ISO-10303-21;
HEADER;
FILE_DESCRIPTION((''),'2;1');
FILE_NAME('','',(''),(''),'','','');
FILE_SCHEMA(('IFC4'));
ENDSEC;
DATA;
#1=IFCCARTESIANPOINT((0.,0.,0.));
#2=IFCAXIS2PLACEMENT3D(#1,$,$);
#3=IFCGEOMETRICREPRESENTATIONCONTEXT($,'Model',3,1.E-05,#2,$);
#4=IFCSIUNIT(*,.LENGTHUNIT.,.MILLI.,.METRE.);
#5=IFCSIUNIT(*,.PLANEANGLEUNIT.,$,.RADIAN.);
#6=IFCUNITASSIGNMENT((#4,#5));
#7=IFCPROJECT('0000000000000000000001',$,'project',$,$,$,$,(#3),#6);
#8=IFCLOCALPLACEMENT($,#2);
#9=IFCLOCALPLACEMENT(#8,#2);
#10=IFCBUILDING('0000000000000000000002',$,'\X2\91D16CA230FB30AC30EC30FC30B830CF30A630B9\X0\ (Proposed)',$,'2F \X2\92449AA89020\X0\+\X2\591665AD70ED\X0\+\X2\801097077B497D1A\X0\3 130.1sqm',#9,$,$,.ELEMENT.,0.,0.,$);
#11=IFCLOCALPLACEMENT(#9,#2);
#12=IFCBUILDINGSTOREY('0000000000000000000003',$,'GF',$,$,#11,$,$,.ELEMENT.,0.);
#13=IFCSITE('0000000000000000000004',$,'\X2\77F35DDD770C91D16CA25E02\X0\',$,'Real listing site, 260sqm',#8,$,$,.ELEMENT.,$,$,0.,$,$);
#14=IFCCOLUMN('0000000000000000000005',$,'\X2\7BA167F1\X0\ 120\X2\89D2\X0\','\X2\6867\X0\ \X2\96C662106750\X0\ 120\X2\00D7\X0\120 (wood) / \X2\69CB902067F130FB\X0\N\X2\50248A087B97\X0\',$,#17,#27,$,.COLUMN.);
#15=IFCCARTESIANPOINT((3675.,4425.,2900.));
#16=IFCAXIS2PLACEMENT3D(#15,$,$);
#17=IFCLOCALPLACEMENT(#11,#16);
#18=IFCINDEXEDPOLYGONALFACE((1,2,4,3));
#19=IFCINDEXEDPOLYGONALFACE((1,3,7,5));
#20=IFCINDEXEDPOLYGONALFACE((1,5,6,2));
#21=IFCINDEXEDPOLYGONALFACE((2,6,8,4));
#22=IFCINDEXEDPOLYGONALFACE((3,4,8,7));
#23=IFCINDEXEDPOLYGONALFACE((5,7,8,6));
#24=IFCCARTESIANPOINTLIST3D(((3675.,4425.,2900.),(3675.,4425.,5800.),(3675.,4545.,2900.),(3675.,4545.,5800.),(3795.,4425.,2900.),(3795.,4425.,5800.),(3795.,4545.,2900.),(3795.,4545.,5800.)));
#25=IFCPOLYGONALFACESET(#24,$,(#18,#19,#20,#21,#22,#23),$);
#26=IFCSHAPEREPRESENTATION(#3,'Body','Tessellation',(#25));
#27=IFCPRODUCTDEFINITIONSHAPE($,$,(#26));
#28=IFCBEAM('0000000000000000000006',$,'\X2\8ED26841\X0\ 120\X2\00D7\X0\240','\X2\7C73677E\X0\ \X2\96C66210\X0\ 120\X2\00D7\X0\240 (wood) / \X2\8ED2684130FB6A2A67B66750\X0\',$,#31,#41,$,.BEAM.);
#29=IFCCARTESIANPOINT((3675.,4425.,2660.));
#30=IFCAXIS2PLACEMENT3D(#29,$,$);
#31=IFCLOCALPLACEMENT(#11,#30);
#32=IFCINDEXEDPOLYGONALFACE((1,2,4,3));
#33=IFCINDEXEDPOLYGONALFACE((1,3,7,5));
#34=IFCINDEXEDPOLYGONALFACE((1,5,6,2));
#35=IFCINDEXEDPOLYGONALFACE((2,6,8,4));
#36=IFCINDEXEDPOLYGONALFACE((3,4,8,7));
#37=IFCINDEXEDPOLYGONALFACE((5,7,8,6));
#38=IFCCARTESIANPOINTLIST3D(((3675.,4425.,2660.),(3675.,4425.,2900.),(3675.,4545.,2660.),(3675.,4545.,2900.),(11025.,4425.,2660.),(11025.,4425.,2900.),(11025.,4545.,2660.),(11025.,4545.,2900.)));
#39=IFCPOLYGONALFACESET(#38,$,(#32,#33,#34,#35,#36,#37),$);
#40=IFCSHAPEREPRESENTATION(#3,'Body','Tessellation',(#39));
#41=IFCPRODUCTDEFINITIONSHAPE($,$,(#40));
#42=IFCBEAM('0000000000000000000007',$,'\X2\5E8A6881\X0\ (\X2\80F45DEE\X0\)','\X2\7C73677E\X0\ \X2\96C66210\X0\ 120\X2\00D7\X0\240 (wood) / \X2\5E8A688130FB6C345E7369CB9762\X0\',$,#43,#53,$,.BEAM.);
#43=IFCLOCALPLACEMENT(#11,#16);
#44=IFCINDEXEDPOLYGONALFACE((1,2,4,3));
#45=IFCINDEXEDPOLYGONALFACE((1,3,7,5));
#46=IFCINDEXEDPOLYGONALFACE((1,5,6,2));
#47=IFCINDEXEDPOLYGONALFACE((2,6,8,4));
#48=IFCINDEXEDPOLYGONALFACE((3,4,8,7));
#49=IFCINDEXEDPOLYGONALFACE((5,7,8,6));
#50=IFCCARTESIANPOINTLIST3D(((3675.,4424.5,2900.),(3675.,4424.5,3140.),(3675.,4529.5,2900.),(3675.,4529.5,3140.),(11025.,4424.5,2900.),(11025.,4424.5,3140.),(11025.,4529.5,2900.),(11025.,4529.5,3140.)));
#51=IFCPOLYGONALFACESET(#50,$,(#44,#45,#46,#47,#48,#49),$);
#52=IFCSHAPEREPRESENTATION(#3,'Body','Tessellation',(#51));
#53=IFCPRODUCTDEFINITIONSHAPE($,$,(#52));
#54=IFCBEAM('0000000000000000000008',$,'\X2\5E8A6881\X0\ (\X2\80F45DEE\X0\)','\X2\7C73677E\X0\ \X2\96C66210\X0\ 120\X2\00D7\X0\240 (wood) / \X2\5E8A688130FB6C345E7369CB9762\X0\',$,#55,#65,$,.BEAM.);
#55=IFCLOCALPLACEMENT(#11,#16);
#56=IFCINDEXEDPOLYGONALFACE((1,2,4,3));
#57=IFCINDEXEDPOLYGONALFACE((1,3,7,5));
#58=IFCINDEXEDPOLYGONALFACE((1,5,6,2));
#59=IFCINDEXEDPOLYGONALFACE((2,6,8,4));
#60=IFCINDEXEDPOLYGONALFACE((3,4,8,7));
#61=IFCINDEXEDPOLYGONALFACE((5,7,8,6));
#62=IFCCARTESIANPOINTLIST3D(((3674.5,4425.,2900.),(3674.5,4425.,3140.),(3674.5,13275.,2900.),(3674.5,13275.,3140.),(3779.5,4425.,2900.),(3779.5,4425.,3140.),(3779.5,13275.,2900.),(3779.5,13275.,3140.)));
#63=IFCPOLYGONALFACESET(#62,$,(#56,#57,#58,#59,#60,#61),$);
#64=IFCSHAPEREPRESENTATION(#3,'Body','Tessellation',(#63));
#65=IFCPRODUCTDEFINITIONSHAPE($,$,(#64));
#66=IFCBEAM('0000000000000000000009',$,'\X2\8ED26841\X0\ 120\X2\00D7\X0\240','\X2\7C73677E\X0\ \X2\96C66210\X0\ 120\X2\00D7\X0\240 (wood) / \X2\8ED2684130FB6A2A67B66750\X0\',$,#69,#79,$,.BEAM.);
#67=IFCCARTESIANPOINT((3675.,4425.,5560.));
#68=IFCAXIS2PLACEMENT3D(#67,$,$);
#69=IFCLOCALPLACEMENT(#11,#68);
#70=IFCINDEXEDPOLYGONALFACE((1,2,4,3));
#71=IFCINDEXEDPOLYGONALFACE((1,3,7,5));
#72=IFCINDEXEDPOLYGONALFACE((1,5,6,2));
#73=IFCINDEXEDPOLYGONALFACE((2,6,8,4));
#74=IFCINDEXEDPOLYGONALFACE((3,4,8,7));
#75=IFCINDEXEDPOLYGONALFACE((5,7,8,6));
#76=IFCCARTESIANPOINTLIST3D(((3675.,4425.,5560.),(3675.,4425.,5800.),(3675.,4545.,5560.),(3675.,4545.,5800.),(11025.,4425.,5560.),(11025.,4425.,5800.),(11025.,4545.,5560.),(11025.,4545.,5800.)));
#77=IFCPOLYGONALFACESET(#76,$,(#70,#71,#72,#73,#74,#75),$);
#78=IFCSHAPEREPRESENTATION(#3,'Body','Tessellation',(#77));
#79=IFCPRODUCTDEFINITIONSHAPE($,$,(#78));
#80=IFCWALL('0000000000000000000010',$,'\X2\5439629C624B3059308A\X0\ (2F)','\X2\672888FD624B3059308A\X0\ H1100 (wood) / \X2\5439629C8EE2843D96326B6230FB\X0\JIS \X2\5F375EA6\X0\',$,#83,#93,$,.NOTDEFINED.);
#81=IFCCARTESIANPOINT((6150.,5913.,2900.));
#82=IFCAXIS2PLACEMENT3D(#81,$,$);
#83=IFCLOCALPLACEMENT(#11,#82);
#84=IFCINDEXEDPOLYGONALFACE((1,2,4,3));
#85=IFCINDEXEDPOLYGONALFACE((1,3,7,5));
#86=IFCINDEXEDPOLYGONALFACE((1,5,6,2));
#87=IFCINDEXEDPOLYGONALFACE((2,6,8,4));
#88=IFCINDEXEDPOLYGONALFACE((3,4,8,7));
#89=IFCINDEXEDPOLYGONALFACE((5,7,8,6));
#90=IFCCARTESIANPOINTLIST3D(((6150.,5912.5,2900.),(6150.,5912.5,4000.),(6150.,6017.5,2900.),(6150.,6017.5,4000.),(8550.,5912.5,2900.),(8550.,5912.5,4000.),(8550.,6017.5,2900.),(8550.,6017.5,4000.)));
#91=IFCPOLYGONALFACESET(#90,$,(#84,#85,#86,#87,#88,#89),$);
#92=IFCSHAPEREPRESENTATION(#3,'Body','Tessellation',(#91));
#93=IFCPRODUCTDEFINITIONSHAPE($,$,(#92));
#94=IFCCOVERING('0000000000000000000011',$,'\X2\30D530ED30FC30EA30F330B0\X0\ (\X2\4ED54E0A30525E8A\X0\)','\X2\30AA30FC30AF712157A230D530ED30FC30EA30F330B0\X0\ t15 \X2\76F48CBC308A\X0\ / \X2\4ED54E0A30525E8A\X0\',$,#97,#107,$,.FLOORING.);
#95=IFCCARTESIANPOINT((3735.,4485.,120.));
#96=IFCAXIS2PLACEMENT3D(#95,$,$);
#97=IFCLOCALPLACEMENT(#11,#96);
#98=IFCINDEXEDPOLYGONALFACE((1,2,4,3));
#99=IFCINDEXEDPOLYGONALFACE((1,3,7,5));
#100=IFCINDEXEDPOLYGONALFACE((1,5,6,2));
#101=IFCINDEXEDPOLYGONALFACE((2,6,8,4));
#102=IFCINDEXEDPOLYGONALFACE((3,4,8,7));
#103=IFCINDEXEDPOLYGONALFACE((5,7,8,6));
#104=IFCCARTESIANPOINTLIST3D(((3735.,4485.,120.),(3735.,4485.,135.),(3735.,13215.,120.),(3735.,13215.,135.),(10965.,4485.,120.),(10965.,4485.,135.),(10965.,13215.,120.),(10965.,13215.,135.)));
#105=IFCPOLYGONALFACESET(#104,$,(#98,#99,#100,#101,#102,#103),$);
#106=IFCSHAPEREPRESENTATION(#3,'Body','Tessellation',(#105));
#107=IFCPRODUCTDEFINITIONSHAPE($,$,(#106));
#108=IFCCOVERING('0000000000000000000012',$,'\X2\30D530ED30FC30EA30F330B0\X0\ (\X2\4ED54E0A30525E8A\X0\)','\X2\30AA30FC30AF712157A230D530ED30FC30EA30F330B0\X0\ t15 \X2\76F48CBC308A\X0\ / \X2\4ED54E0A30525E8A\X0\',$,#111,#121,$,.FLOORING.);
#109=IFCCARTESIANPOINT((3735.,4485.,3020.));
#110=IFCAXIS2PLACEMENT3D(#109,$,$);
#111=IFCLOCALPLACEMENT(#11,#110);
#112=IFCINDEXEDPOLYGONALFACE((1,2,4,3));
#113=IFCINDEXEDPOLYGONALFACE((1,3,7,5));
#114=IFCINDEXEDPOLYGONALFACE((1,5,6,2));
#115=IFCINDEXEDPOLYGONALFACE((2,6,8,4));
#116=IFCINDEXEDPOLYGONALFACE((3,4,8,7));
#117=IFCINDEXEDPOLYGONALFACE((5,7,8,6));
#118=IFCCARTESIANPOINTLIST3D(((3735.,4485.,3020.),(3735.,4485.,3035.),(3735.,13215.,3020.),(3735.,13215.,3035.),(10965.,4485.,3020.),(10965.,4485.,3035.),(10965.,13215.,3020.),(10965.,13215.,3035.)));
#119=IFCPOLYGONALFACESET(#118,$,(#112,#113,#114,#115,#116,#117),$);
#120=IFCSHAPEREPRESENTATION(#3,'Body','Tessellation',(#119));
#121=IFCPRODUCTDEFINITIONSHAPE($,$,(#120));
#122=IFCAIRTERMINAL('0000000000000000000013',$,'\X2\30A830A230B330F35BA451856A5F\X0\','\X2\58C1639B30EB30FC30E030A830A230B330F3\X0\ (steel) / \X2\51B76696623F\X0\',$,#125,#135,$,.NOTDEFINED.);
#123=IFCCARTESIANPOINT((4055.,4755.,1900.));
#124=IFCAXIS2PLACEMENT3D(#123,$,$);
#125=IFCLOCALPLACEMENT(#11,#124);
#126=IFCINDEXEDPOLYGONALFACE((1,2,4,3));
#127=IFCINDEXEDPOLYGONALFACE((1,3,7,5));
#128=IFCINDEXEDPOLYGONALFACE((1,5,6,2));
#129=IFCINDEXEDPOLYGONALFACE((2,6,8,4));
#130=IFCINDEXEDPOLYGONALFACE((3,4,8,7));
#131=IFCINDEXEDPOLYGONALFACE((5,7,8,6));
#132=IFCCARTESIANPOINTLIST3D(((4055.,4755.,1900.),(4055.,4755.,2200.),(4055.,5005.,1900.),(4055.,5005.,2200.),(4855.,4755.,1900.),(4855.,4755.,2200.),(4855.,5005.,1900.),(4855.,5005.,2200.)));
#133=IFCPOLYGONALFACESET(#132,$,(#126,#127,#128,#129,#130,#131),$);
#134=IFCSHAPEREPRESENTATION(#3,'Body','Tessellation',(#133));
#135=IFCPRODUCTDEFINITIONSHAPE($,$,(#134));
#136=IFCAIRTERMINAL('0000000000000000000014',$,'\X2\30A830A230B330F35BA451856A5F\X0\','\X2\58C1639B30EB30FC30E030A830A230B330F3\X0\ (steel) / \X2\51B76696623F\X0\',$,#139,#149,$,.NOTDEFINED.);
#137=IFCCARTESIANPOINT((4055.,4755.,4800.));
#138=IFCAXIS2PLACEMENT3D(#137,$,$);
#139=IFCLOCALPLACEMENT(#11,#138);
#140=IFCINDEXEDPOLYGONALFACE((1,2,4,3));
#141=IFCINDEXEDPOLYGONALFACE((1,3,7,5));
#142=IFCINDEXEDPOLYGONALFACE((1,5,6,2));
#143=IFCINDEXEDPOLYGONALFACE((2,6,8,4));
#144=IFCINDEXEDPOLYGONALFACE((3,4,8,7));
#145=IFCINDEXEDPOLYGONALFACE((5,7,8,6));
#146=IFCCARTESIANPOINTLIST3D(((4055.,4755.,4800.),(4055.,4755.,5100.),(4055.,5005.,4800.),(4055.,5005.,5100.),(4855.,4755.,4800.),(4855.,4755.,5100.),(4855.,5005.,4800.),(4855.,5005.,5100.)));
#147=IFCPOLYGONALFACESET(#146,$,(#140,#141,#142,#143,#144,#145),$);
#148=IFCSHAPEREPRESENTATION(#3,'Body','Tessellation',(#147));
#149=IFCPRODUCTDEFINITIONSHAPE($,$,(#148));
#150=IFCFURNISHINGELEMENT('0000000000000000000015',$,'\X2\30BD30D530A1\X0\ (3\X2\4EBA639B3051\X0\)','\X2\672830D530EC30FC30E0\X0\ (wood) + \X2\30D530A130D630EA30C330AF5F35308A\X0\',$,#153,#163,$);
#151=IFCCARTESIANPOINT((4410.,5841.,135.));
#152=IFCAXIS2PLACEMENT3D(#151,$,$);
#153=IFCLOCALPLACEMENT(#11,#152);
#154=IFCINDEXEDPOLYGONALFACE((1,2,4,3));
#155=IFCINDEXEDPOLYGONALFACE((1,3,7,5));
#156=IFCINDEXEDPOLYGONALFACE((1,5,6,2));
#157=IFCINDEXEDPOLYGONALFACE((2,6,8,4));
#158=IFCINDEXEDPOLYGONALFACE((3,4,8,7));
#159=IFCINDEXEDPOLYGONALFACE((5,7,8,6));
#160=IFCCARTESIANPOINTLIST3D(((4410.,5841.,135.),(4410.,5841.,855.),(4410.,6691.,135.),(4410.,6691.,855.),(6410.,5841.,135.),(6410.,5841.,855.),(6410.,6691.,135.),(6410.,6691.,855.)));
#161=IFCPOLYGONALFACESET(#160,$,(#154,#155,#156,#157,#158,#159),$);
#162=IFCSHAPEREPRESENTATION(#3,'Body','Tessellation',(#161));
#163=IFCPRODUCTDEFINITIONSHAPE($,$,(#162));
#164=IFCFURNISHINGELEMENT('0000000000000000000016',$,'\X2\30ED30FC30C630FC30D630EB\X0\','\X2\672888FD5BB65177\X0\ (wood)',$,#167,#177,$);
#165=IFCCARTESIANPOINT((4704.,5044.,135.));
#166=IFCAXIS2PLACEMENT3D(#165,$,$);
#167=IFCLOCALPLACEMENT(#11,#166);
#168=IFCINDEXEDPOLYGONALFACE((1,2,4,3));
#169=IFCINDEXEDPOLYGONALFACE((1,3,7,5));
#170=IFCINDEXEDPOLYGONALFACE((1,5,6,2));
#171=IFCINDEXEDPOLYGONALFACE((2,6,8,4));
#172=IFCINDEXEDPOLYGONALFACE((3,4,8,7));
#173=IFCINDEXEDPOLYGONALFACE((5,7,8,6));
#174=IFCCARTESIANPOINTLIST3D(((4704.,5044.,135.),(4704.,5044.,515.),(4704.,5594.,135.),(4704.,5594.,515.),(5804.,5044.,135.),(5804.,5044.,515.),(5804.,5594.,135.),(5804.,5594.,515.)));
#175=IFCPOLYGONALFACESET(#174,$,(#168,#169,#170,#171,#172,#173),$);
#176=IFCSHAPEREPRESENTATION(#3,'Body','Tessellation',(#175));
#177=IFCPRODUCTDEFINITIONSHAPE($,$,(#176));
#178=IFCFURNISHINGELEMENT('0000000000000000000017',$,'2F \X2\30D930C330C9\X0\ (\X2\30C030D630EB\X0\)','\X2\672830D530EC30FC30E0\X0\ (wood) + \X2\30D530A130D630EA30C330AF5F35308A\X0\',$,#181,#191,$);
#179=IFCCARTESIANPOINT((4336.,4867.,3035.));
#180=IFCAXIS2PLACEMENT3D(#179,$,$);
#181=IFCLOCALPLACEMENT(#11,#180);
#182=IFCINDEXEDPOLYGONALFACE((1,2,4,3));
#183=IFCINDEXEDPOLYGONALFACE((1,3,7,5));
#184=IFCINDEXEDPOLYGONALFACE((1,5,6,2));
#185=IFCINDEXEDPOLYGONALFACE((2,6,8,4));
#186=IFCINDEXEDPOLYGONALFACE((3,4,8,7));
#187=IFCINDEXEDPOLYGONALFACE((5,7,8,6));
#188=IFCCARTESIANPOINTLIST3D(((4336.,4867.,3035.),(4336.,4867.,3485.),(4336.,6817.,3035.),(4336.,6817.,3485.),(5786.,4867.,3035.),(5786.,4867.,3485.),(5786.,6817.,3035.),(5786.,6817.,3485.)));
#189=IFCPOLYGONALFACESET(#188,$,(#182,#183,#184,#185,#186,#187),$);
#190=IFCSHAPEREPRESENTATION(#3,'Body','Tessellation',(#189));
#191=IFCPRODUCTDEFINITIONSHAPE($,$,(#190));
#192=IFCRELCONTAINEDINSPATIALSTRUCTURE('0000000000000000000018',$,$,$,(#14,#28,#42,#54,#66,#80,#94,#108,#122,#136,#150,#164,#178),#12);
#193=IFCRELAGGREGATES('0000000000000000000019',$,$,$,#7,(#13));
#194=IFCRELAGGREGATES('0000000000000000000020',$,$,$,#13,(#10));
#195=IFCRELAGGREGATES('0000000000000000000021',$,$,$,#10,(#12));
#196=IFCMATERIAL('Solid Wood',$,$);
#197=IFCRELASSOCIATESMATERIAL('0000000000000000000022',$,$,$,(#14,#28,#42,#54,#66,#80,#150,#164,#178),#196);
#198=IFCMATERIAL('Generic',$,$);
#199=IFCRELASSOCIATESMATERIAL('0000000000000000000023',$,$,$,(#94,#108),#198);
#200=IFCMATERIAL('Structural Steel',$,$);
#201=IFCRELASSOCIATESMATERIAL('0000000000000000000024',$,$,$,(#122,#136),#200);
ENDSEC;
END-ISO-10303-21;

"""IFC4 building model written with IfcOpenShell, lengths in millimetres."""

from ifc_helpers import new_model, si_unit, frame, frame_2d, origin, place, context, project, spatial, rectangle, extrude, material, element, save


model = new_model("IFC4")

# Units and contexts
model_context = context("Model", 3, precision=1e-05, world=origin())
ifc_project = project(units=[si_unit("LENGTHUNIT", "METRE", prefix="MILLI"), si_unit("PLANEANGLEUNIT", "RADIAN")], contexts=[model_context])

# Site, building, storey
site_placement = place(None, origin())
site = spatial("IfcSite", under=ifc_project, at=site_placement, Name="石川県金沢市", ObjectType="Real listing site, 260sqm", CompositionType="ELEMENT", RefElevation=0.0)
building_placement = place(site_placement, origin())
building = spatial("IfcBuilding", under=site, at=building_placement, Name="金沢・ガレージハウス (Proposed)", ObjectType="2F 鉄骨造+外断热+耐震等級3 130.1sqm", CompositionType="ELEMENT", ElevationOfRefHeight=0.0, ElevationOfTerrain=0.0)
storey_placement = place(building_placement, origin())
storey = spatial("IfcBuildingStorey", under=building, at=storey_placement, Name="GF", CompositionType="ELEMENT", Elevation=0.0)

# Column
ifc_material_1 = material(Name="Solid Wood")
column_1_placement = place(storey_placement, frame((3675.0, 4425.0, 2900.0)))
element("IfcColumn", 1, at=column_1_placement, inside=storey, material=ifc_material_1, Name="管柱 120角", Description="桧 集成材 120×120 (wood) / 構造柱・N値計算", PredefinedType="COLUMN", context=model_context, shape_type="SweptSolid", body=[
    extrude(rectangle(XDim=120.0, YDim=120.0, at=frame_2d((60.0, 60.0))), frame((3675.0, 4425.0, 2900.0)), (0.0, 0.0, 1.0), 2900.0),
])

# Beams
beam_1_placement = place(storey_placement, frame((3675.0, 4425.0, 2660.0)))
element("IfcBeam", 2, at=beam_1_placement, inside=storey, material=ifc_material_1, Name="軒桁 120×240", Description="米松 集成 120×240 (wood) / 軒桁・横架材", PredefinedType="BEAM", context=model_context, shape_type="SweptSolid", body=[
    extrude(rectangle(XDim=7350.0, YDim=120.0, at=frame_2d((3675.0, 60.0))), frame((3675.0, 4425.0, 2660.0)), (0.0, 0.0, 1.0), 240.0),
])
beam_2_placement = place(storey_placement, frame((3675.0, 4425.0, 2900.0)))
element("IfcBeam", 3, at=beam_2_placement, inside=storey, material=ifc_material_1, Name="床梁 (胴差)", Description="米松 集成 120×240 (wood) / 床梁・水平構面", PredefinedType="BEAM", context=model_context, shape_type="SweptSolid", body=[
    extrude(rectangle(XDim=7350.0, YDim=105.0, at=frame_2d((3675.0, 52.0))), frame((3675.0, 4425.0, 2900.0)), (0.0, 0.0, 1.0), 240.0),
])
beam_3_placement = place(storey_placement, frame((3675.0, 4425.0, 2900.0)))
element("IfcBeam", 4, at=beam_3_placement, inside=storey, material=ifc_material_1, Name="床梁 (胴差)", Description="米松 集成 120×240 (wood) / 床梁・水平構面", PredefinedType="BEAM", context=model_context, shape_type="SweptSolid", body=[
    extrude(rectangle(XDim=105.0, YDim=8850.0, at=frame_2d((52.0, 4425.0))), frame((3675.0, 4425.0, 2900.0)), (0.0, 0.0, 1.0), 240.0),
])
beam_4_placement = place(storey_placement, frame((3675.0, 4425.0, 5560.0)))
element("IfcBeam", 5, at=beam_4_placement, inside=storey, material=ifc_material_1, Name="軒桁 120×240", Description="米松 集成 120×240 (wood) / 軒桁・横架材", PredefinedType="BEAM", context=model_context, shape_type="SweptSolid", body=[
    extrude(rectangle(XDim=7350.0, YDim=120.0, at=frame_2d((3675.0, 60.0))), frame((3675.0, 4425.0, 5560.0)), (0.0, 0.0, 1.0), 240.0),
])

# Wall
wall_placement = place(storey_placement, frame((6150.0, 5913.0, 2900.0)))
element("IfcWall", 6, at=wall_placement, inside=storey, material=ifc_material_1, Name="吹抜手すり (2F)", Description="木製手すり H1100 (wood) / 吹抜転落防止・JIS 強度", PredefinedType="NOTDEFINED", context=model_context, shape_type="SweptSolid", body=[
    extrude(rectangle(XDim=2400.0, YDim=105.0, at=frame_2d((1200.0, 52.0))), frame((6150.0, 5913.0, 2900.0)), (0.0, 0.0, 1.0), 1100.0),
])

# Coverings
ifc_material_2 = material(Name="Generic")
covering_1_placement = place(storey_placement, frame((3735.0, 4485.0, 120.0)))
element("IfcCovering", 7, at=covering_1_placement, inside=storey, material=ifc_material_2, Name="フローリング (仕上げ床)", Description="オーク無垢フローリング t15 直貼り / 仕上げ床", PredefinedType="FLOORING", context=model_context, shape_type="SweptSolid", body=[
    extrude(rectangle(XDim=7230.0, YDim=8730.0, at=frame_2d((3615.0, 4365.0))), frame((3735.0, 4485.0, 120.0)), (0.0, 0.0, 1.0), 15.0),
])
covering_2_placement = place(storey_placement, frame((3735.0, 4485.0, 3020.0)))
element("IfcCovering", 8, at=covering_2_placement, inside=storey, material=ifc_material_2, Name="フローリング (仕上げ床)", Description="オーク無垢フローリング t15 直貼り / 仕上げ床", PredefinedType="FLOORING", context=model_context, shape_type="SweptSolid", body=[
    extrude(rectangle(XDim=7230.0, YDim=8730.0, at=frame_2d((3615.0, 4365.0))), frame((3735.0, 4485.0, 3020.0)), (0.0, 0.0, 1.0), 15.0),
])

# Air terminals
ifc_material_3 = material(Name="Structural Steel")
air_terminal_1_placement = place(storey_placement, frame((4055.0, 4755.0, 1900.0)))
element("IfcAirTerminal", 9, at=air_terminal_1_placement, inside=storey, material=ifc_material_3, Name="エアコン室内機", Description="壁掛ルームエアコン (steel) / 冷暖房", PredefinedType="NOTDEFINED", context=model_context, shape_type="SweptSolid", body=[
    extrude(rectangle(XDim=800.0, YDim=250.0, at=frame_2d((400.0, 125.0))), frame((4055.0, 4755.0, 1900.0)), (0.0, 0.0, 1.0), 300.0),
])
air_terminal_2_placement = place(storey_placement, frame((4055.0, 4755.0, 4800.0)))
element("IfcAirTerminal", 10, at=air_terminal_2_placement, inside=storey, material=ifc_material_3, Name="エアコン室内機", Description="壁掛ルームエアコン (steel) / 冷暖房", PredefinedType="NOTDEFINED", context=model_context, shape_type="SweptSolid", body=[
    extrude(rectangle(XDim=800.0, YDim=250.0, at=frame_2d((400.0, 125.0))), frame((4055.0, 4755.0, 4800.0)), (0.0, 0.0, 1.0), 300.0),
])

# Furnishing elements
furnishing_1_placement = place(storey_placement, frame((4410.0, 5841.0, 135.0)))
element("IfcFurnishingElement", 11, at=furnishing_1_placement, inside=storey, material=ifc_material_1, Name="ソファ (3人掛け)", Description="木フレーム (wood) + ファブリック張り", context=model_context, shape_type="SweptSolid", body=[
    extrude(rectangle(XDim=2000.0, YDim=850.0, at=frame_2d((1000.0, 425.0))), frame((4410.0, 5841.0, 135.0)), (0.0, 0.0, 1.0), 720.0),
])
furnishing_2_placement = place(storey_placement, frame((4704.0, 5044.0, 135.0)))
element("IfcFurnishingElement", 12, at=furnishing_2_placement, inside=storey, material=ifc_material_1, Name="ローテーブル", Description="木製家具 (wood)", context=model_context, shape_type="SweptSolid", body=[
    extrude(rectangle(XDim=1100.0, YDim=550.0, at=frame_2d((550.0, 275.0))), frame((4704.0, 5044.0, 135.0)), (0.0, 0.0, 1.0), 380.0),
])
furnishing_3_placement = place(storey_placement, frame((4336.0, 4867.0, 3035.0)))
element("IfcFurnishingElement", 13, at=furnishing_3_placement, inside=storey, material=ifc_material_1, Name="2F ベッド (ダブル)", Description="木フレーム (wood) + ファブリック張り", context=model_context, shape_type="SweptSolid", body=[
    extrude(rectangle(XDim=1450.0, YDim=1950.0, at=frame_2d((725.0, 975.0))), frame((4336.0, 4867.0, 3035.0)), (0.0, 0.0, 1.0), 450.0),
])

save(model, "model.ifc")
